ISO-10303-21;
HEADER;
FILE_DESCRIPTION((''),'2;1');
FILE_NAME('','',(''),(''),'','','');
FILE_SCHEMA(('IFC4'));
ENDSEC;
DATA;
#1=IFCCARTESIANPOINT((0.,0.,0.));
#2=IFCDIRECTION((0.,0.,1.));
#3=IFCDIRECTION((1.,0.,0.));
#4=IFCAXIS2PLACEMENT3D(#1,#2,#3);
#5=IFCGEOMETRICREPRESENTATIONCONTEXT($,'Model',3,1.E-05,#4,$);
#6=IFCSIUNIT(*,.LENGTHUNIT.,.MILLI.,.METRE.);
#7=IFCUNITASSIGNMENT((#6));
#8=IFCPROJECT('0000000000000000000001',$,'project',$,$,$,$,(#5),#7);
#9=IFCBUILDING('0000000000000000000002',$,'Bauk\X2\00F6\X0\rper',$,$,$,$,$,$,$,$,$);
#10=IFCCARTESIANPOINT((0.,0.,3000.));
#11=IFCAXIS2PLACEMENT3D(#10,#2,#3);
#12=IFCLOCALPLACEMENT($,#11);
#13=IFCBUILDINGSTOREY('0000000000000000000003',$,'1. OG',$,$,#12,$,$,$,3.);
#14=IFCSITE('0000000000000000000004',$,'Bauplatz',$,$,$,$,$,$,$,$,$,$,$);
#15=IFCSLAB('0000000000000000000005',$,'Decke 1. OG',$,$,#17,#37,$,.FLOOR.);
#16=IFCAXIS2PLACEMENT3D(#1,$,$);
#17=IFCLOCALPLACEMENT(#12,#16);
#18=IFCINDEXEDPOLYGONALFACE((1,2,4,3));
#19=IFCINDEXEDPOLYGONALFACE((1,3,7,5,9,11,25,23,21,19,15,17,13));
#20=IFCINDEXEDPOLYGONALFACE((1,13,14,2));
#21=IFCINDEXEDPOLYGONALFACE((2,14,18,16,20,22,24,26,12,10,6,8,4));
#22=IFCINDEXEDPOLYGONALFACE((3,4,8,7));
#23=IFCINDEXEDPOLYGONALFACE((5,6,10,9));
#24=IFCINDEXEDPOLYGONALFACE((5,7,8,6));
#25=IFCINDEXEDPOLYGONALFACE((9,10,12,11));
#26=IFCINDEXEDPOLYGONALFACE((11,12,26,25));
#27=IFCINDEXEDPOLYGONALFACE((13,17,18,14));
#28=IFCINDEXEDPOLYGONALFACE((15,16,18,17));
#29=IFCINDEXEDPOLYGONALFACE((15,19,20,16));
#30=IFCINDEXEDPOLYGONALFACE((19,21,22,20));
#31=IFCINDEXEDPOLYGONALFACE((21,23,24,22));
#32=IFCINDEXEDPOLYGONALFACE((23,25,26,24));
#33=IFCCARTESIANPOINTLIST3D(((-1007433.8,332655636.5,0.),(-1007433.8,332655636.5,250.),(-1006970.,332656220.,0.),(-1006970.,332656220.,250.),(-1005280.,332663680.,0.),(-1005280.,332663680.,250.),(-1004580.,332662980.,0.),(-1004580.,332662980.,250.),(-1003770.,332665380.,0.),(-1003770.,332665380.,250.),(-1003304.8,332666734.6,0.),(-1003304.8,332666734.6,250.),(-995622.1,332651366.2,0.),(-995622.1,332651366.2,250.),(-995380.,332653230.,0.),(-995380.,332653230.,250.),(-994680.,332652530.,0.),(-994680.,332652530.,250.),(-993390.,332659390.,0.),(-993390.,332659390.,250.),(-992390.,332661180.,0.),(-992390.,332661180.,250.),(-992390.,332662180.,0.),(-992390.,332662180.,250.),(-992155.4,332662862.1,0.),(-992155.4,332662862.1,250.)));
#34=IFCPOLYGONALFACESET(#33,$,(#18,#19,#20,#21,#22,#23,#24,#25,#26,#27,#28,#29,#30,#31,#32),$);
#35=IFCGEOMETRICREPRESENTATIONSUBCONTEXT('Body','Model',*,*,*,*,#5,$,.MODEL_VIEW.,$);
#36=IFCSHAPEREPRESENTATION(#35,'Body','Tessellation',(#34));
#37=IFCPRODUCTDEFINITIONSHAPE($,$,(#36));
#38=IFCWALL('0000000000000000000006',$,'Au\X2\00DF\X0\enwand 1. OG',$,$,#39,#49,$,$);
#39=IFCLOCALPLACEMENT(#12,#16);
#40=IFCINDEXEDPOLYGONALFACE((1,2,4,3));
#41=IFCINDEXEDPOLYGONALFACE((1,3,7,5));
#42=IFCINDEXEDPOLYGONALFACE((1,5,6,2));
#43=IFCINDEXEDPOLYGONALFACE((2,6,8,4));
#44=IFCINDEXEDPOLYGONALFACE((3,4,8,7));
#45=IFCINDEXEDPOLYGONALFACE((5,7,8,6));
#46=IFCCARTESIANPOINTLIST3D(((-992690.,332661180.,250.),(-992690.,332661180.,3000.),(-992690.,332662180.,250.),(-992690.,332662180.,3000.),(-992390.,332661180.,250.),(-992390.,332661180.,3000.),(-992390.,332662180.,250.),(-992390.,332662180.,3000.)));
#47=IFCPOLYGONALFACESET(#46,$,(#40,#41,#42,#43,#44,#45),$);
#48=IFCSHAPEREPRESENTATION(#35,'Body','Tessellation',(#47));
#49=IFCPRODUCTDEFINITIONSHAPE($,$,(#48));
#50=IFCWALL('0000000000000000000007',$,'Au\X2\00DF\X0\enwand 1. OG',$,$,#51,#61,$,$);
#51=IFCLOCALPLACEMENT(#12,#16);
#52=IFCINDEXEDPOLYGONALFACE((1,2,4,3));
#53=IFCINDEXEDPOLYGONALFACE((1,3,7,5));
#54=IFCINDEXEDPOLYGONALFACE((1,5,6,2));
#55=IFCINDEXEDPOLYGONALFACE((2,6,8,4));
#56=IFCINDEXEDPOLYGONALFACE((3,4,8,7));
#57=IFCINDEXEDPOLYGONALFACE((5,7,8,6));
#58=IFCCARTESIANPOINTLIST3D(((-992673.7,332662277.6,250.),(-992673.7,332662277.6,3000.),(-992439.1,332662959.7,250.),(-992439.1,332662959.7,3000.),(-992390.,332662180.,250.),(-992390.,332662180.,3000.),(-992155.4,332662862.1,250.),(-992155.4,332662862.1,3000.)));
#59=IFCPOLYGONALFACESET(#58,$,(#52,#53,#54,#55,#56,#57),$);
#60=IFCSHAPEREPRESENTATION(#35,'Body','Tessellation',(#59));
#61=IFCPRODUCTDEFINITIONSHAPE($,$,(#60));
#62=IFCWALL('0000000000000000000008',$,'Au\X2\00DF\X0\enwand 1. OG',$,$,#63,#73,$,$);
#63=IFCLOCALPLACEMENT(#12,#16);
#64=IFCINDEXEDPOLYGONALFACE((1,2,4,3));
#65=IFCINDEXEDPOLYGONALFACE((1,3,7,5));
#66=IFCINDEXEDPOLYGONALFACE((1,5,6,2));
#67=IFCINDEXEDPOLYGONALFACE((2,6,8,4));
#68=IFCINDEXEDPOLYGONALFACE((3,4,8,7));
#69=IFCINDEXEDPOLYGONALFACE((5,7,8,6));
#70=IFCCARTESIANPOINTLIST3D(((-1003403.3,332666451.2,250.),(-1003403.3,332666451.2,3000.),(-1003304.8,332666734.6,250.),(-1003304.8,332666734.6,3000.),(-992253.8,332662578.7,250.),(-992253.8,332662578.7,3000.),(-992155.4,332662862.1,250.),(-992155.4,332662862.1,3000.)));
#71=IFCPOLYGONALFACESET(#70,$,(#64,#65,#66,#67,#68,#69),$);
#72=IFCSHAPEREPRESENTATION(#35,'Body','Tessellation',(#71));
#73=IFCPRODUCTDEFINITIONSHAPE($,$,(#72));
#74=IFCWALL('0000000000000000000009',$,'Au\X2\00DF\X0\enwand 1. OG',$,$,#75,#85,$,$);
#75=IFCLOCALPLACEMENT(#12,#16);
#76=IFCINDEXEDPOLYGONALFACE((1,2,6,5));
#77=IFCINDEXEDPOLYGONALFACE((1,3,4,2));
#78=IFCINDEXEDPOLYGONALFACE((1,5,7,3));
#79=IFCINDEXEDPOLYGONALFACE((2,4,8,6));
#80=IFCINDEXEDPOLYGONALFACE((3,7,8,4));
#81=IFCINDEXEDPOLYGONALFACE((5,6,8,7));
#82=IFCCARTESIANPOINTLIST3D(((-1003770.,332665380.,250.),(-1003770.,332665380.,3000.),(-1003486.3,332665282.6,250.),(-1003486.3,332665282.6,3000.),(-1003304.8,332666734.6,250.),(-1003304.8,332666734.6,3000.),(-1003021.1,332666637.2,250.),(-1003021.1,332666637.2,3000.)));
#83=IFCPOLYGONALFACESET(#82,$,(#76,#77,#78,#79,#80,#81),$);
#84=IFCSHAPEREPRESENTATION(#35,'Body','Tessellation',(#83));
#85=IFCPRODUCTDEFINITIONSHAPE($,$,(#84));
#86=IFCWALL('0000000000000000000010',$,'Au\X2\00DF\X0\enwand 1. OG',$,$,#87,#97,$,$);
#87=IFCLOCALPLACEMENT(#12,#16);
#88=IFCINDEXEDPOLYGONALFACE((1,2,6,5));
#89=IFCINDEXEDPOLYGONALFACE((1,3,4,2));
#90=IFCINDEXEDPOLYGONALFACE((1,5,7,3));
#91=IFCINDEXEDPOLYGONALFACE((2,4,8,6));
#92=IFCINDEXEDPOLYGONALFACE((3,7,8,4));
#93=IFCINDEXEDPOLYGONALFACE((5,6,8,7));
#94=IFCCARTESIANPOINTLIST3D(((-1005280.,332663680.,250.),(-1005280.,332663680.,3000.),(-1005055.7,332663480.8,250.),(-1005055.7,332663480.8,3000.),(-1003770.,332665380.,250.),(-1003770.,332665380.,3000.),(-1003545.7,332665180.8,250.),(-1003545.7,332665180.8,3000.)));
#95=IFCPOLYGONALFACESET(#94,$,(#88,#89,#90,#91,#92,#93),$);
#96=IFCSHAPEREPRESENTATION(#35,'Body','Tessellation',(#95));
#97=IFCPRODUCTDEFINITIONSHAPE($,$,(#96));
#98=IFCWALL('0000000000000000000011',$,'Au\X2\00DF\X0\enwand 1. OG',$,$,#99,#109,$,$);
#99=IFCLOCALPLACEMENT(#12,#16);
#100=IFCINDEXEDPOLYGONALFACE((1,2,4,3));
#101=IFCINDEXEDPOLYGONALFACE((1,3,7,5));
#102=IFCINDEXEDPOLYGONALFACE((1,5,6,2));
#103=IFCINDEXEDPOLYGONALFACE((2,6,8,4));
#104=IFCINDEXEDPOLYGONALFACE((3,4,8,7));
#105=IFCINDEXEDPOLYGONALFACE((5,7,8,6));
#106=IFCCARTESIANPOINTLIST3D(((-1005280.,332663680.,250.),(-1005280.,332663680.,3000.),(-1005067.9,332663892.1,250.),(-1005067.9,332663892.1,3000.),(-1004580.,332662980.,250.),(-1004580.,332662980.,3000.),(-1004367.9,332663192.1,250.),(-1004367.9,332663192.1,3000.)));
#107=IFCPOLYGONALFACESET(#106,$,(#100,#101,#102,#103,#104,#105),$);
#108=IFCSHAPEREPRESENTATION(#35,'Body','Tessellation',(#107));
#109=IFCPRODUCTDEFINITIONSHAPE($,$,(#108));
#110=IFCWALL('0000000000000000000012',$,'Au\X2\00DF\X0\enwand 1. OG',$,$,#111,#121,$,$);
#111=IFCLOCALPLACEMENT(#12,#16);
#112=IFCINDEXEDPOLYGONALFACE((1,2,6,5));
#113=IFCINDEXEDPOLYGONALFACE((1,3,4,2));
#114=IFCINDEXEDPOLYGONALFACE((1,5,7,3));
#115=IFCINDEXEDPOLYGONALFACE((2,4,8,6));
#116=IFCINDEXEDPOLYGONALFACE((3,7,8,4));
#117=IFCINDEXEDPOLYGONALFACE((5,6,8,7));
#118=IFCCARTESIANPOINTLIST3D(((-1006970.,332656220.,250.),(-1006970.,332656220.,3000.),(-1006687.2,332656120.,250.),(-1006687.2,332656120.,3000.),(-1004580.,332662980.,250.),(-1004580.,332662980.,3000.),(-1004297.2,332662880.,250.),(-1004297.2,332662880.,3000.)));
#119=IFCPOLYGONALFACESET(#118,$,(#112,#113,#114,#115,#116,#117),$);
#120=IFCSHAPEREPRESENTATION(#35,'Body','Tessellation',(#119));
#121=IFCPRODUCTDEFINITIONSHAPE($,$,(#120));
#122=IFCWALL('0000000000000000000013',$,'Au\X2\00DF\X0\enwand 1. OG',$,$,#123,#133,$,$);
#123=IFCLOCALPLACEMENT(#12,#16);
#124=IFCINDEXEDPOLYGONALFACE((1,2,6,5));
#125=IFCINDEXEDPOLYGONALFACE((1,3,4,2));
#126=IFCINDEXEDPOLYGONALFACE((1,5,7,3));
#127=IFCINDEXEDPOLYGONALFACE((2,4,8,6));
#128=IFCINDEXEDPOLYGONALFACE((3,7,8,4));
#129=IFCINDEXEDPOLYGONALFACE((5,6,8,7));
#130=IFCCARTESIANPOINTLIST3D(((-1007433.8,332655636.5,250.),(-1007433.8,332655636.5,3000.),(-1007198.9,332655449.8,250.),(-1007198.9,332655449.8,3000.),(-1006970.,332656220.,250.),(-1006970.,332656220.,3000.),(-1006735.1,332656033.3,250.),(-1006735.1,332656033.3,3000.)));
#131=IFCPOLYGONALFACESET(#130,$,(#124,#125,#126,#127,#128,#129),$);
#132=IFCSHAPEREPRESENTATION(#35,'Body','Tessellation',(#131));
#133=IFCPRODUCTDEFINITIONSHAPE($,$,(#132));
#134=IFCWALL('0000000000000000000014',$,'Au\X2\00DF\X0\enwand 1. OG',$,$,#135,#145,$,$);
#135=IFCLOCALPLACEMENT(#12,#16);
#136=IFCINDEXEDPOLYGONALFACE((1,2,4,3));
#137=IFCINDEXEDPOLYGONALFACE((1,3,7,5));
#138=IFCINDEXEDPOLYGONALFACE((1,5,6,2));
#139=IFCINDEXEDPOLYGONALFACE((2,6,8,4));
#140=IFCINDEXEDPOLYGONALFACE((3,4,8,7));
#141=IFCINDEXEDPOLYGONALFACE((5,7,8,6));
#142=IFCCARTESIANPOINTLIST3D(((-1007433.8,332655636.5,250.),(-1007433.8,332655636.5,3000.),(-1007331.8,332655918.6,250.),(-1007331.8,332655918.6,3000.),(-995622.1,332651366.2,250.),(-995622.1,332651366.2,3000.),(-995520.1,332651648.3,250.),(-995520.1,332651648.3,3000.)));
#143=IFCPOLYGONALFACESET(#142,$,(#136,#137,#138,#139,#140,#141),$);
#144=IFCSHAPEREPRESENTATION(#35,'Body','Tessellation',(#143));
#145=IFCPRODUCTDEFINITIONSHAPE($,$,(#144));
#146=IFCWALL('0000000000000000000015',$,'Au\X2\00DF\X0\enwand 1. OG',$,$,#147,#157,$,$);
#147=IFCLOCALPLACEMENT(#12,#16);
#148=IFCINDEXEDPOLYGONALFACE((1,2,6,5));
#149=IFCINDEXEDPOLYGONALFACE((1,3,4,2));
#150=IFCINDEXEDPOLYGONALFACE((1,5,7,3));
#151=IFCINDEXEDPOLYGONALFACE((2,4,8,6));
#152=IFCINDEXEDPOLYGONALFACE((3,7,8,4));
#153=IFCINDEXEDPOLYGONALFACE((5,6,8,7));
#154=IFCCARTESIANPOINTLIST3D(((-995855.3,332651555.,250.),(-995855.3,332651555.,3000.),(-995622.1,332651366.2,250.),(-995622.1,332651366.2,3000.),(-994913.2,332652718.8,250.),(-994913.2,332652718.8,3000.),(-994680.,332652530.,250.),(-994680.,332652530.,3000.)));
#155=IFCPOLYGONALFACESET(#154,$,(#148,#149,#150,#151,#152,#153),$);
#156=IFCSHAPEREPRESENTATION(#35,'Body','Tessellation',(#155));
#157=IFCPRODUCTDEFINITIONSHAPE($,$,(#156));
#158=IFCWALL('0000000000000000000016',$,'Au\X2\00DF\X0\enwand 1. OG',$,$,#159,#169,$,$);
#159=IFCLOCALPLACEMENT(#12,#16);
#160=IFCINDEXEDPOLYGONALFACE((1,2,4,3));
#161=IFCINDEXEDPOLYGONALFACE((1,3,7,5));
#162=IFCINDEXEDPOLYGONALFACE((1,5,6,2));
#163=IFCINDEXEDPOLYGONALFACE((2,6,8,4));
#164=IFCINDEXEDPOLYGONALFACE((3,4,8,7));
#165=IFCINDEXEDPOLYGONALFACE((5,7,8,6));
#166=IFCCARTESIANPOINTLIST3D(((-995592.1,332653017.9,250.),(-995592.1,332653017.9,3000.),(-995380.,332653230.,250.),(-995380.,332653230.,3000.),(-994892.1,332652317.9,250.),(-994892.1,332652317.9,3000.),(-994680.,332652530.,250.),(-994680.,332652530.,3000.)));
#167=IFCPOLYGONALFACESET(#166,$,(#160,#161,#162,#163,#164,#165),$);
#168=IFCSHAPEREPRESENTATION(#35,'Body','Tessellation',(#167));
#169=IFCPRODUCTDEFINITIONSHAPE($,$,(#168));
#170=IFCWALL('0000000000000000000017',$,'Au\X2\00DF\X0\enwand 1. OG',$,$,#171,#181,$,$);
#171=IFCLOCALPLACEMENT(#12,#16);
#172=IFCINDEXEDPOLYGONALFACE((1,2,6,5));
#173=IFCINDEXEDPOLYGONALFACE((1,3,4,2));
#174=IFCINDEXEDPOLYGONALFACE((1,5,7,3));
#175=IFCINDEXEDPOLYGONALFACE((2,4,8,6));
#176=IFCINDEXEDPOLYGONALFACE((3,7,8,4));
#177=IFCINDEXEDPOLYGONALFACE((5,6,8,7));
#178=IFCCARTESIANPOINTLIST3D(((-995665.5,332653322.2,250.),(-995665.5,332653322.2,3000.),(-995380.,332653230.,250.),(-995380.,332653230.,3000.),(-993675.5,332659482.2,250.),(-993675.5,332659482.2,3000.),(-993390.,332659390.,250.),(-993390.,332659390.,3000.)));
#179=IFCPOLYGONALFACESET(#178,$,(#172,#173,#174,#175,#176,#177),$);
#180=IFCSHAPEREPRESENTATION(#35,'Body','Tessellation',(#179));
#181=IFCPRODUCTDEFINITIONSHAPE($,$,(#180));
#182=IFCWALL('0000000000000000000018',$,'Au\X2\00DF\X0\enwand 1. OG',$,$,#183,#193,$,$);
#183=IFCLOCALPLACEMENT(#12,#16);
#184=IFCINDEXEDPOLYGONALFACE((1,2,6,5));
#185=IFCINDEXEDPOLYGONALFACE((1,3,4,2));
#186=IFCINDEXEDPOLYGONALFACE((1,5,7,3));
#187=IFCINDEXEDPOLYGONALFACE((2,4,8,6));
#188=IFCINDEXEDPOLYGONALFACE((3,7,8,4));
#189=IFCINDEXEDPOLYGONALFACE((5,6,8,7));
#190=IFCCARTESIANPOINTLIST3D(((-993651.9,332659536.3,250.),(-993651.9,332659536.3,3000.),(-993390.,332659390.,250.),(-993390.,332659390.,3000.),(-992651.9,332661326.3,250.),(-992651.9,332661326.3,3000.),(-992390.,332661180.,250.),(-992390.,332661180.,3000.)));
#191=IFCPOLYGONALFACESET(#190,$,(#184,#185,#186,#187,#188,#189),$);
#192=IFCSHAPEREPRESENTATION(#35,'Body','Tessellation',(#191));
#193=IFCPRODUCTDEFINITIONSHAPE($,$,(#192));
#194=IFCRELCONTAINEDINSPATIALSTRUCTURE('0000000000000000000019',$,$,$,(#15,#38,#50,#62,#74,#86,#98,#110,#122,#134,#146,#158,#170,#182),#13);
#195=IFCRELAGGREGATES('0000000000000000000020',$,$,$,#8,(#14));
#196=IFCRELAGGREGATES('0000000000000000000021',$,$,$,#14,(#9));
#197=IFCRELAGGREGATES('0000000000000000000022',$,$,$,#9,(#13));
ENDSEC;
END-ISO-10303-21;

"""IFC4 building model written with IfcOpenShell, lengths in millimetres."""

from ifc_helpers import new_model, si_unit, frame, origin_with_axes, place, context, subcontext, project, spatial, indexed_curve, outline, extrude, element, save


model = new_model("IFC4")

# Units and contexts
model_context = context("Model", 3, precision=1e-05, world=origin_with_axes())
body_context = subcontext(model_context, "Body", "Model", "MODEL_VIEW")
ifc_project = project(units=[si_unit("LENGTHUNIT", "METRE", prefix="MILLI")], contexts=[model_context])

# Site, building, storey
site = spatial("IfcSite", under=ifc_project, Name="Bauplatz")
building = spatial("IfcBuilding", under=site, Name="Baukörper")
storey_placement = place(None, frame((0.0, 0.0, 3000.0), z_axis=(0.0, 0.0, 1.0), x_axis=(1.0, 0.0, 0.0)))
storey = spatial("IfcBuildingStorey", under=building, at=storey_placement, Name="1. OG", Elevation=3.0)

# Slab
slab_placement = place(storey_placement, origin_with_axes())
element("IfcSlab", 1, at=slab_placement, inside=storey, Name="Decke 1. OG", PredefinedType="FLOOR", context=body_context, shape_type="SweptSolid", body=[
    extrude(outline(indexed_curve([(-992390.0, 332661180.0), (-993390.0, 332659390.0), (-995380.0, 332653230.0), (-994680.0, 332652530.0), (-995622.1, 332651366.2), (-1007433.8, 332655636.5), (-1006970.0, 332656220.0), (-1004580.0, 332662980.0), (-1005280.0, 332663680.0), (-1003770.0, 332665380.0), (-1003304.8, 332666734.6), (-992155.4, 332662862.1), (-992390.0, 332662180.0)])), None, (0.0, 0.0, 1.0), 250.0),
])

# Walls
wall_1_placement = place(storey_placement, frame((-992390.0, 332661180.0, 250.0), z_axis=(0.0, 0.0, 1.0), x_axis=(0.0, 1.0, 0.0)))
element("IfcWall", 2, at=wall_1_placement, inside=storey, Name="Außenwand 1. OG", context=body_context, shape_type="SweptSolid", body=[
    extrude(outline(indexed_curve([(0.0, 0.0), (0.0, 300.0), (1000.0, 300.0), (1000.0, 0.0), (0.0, 0.0)], self_intersect=False)), origin_with_axes(), (0.0, 0.0, 1.0), 2750.0),
])
wall_2_placement = place(storey_placement, frame((-992390.0, 332662180.0, 250.0), z_axis=(0.0, 0.0, 1.0), x_axis=(0.32522, 0.945639, 0.0)))
element("IfcWall", 3, at=wall_2_placement, inside=storey, Name="Außenwand 1. OG", context=body_context, shape_type="SweptSolid", body=[
    extrude(outline(indexed_curve([(0.0, 0.0), (0.0, 300.0), (721.3, 300.0), (721.3, 0.0), (0.0, 0.0)], self_intersect=False)), origin_with_axes(), (0.0, 0.0, 1.0), 2750.0),
])
wall_3_placement = place(storey_placement, frame((-992155.4, 332662862.1, 250.0), z_axis=(0.0, 0.0, 1.0), x_axis=(-0.944643, 0.328101, 0.0)))
element("IfcWall", 4, at=wall_3_placement, inside=storey, Name="Außenwand 1. OG", context=body_context, shape_type="SweptSolid", body=[
    extrude(outline(indexed_curve([(0.0, 0.0), (0.0, 300.0), (11802.8, 300.0), (11802.8, 0.0), (0.0, 0.0)], self_intersect=False)), origin_with_axes(), (0.0, 0.0, 1.0), 2750.0),
])
wall_4_placement = place(storey_placement, frame((-1003304.8, 332666734.6, 250.0), z_axis=(0.0, 0.0, 1.0), x_axis=(-0.324776, -0.945791, 0.0)))
element("IfcWall", 5, at=wall_4_placement, inside=storey, Name="Außenwand 1. OG", context=body_context, shape_type="SweptSolid", body=[
    extrude(outline(indexed_curve([(0.0, 0.0), (0.0, 300.0), (1432.3, 300.0), (1432.3, 0.0), (0.0, 0.0)], self_intersect=False)), origin_with_axes(), (0.0, 0.0, 1.0), 2750.0),
])
wall_5_placement = place(storey_placement, frame((-1003770.0, 332665380.0, 250.0), z_axis=(0.0, 0.0, 1.0), x_axis=(-0.664091, -0.747652, 0.0)))
element("IfcWall", 6, at=wall_5_placement, inside=storey, Name="Außenwand 1. OG", context=body_context, shape_type="SweptSolid", body=[
    extrude(outline(indexed_curve([(0.0, 0.0), (0.0, 300.0), (2273.8, 300.0), (2273.8, 0.0), (0.0, 0.0)], self_intersect=False)), origin_with_axes(), (0.0, 0.0, 1.0), 2750.0),
])
wall_6_placement = place(storey_placement, frame((-1005280.0, 332663680.0, 250.0), z_axis=(0.0, 0.0, 1.0), x_axis=(0.707107, -0.707107, 0.0)))
element("IfcWall", 7, at=wall_6_placement, inside=storey, Name="Außenwand 1. OG", context=body_context, shape_type="SweptSolid", body=[
    extrude(outline(indexed_curve([(0.0, 0.0), (0.0, 300.0), (989.9, 300.0), (989.9, 0.0), (0.0, 0.0)], self_intersect=False)), origin_with_axes(), (0.0, 0.0, 1.0), 2750.0),
])
wall_7_placement = place(storey_placement, frame((-1004580.0, 332662980.0, 250.0), z_axis=(0.0, 0.0, 1.0), x_axis=(-0.333331, -0.94281, 0.0)))
element("IfcWall", 8, at=wall_7_placement, inside=storey, Name="Außenwand 1. OG", context=body_context, shape_type="SweptSolid", body=[
    extrude(outline(indexed_curve([(0.0, 0.0), (0.0, 300.0), (7170.1, 300.0), (7170.1, 0.0), (0.0, 0.0)], self_intersect=False)), origin_with_axes(), (0.0, 0.0, 1.0), 2750.0),
])
wall_8_placement = place(storey_placement, frame((-1006970.0, 332656220.0, 250.0), z_axis=(0.0, 0.0, 1.0), x_axis=(-0.622179, -0.782875, 0.0)))
element("IfcWall", 9, at=wall_8_placement, inside=storey, Name="Außenwand 1. OG", context=body_context, shape_type="SweptSolid", body=[
    extrude(outline(indexed_curve([(0.0, 0.0), (0.0, 300.0), (745.4, 300.0), (745.4, 0.0), (0.0, 0.0)], self_intersect=False)), origin_with_axes(), (0.0, 0.0, 1.0), 2750.0),
])
wall_9_placement = place(storey_placement, frame((-1007433.8, 332655636.5, 250.0), z_axis=(0.0, 0.0, 1.0), x_axis=(0.940428, -0.339993, 0.0)))
element("IfcWall", 10, at=wall_9_placement, inside=storey, Name="Außenwand 1. OG", context=body_context, shape_type="SweptSolid", body=[
    extrude(outline(indexed_curve([(0.0, 0.0), (0.0, 300.0), (12559.9, 300.0), (12559.9, 0.0), (0.0, 0.0)], self_intersect=False)), origin_with_axes(), (0.0, 0.0, 1.0), 2750.0),
])
wall_10_placement = place(storey_placement, frame((-995622.1, 332651366.2, 250.0), z_axis=(0.0, 0.0, 1.0), x_axis=(0.629198, 0.777245, 0.0)))
element("IfcWall", 11, at=wall_10_placement, inside=storey, Name="Außenwand 1. OG", context=body_context, shape_type="SweptSolid", body=[
    extrude(outline(indexed_curve([(0.0, 0.0), (0.0, 300.0), (1497.3, 300.0), (1497.3, 0.0), (0.0, 0.0)], self_intersect=False)), origin_with_axes(), (0.0, 0.0, 1.0), 2750.0),
])
wall_11_placement = place(storey_placement, frame((-994680.0, 332652530.0, 250.0), z_axis=(0.0, 0.0, 1.0), x_axis=(-0.707107, 0.707107, 0.0)))
element("IfcWall", 12, at=wall_11_placement, inside=storey, Name="Außenwand 1. OG", context=body_context, shape_type="SweptSolid", body=[
    extrude(outline(indexed_curve([(0.0, 0.0), (0.0, 300.0), (989.9, 300.0), (989.9, 0.0), (0.0, 0.0)], self_intersect=False)), origin_with_axes(), (0.0, 0.0, 1.0), 2750.0),
])
wall_12_placement = place(storey_placement, frame((-995380.0, 332653230.0, 250.0), z_axis=(0.0, 0.0, 1.0), x_axis=(0.307409, 0.951577, 0.0)))
element("IfcWall", 13, at=wall_12_placement, inside=storey, Name="Außenwand 1. OG", context=body_context, shape_type="SweptSolid", body=[
    extrude(outline(indexed_curve([(0.0, 0.0), (0.0, 300.0), (6473.5, 300.0), (6473.5, 0.0), (0.0, 0.0)], self_intersect=False)), origin_with_axes(), (0.0, 0.0, 1.0), 2750.0),
])
wall_13_placement = place(storey_placement, frame((-993390.0, 332659390.0, 250.0), z_axis=(0.0, 0.0, 1.0), x_axis=(0.487712, 0.873005, 0.0)))
element("IfcWall", 14, at=wall_13_placement, inside=storey, Name="Außenwand 1. OG", context=body_context, shape_type="SweptSolid", body=[
    extrude(outline(indexed_curve([(0.0, 0.0), (0.0, 300.0), (2050.4, 300.0), (2050.4, 0.0), (0.0, 0.0)], self_intersect=False)), origin_with_axes(), (0.0, 0.0, 1.0), 2750.0),
])

save(model, "model.ifc")
